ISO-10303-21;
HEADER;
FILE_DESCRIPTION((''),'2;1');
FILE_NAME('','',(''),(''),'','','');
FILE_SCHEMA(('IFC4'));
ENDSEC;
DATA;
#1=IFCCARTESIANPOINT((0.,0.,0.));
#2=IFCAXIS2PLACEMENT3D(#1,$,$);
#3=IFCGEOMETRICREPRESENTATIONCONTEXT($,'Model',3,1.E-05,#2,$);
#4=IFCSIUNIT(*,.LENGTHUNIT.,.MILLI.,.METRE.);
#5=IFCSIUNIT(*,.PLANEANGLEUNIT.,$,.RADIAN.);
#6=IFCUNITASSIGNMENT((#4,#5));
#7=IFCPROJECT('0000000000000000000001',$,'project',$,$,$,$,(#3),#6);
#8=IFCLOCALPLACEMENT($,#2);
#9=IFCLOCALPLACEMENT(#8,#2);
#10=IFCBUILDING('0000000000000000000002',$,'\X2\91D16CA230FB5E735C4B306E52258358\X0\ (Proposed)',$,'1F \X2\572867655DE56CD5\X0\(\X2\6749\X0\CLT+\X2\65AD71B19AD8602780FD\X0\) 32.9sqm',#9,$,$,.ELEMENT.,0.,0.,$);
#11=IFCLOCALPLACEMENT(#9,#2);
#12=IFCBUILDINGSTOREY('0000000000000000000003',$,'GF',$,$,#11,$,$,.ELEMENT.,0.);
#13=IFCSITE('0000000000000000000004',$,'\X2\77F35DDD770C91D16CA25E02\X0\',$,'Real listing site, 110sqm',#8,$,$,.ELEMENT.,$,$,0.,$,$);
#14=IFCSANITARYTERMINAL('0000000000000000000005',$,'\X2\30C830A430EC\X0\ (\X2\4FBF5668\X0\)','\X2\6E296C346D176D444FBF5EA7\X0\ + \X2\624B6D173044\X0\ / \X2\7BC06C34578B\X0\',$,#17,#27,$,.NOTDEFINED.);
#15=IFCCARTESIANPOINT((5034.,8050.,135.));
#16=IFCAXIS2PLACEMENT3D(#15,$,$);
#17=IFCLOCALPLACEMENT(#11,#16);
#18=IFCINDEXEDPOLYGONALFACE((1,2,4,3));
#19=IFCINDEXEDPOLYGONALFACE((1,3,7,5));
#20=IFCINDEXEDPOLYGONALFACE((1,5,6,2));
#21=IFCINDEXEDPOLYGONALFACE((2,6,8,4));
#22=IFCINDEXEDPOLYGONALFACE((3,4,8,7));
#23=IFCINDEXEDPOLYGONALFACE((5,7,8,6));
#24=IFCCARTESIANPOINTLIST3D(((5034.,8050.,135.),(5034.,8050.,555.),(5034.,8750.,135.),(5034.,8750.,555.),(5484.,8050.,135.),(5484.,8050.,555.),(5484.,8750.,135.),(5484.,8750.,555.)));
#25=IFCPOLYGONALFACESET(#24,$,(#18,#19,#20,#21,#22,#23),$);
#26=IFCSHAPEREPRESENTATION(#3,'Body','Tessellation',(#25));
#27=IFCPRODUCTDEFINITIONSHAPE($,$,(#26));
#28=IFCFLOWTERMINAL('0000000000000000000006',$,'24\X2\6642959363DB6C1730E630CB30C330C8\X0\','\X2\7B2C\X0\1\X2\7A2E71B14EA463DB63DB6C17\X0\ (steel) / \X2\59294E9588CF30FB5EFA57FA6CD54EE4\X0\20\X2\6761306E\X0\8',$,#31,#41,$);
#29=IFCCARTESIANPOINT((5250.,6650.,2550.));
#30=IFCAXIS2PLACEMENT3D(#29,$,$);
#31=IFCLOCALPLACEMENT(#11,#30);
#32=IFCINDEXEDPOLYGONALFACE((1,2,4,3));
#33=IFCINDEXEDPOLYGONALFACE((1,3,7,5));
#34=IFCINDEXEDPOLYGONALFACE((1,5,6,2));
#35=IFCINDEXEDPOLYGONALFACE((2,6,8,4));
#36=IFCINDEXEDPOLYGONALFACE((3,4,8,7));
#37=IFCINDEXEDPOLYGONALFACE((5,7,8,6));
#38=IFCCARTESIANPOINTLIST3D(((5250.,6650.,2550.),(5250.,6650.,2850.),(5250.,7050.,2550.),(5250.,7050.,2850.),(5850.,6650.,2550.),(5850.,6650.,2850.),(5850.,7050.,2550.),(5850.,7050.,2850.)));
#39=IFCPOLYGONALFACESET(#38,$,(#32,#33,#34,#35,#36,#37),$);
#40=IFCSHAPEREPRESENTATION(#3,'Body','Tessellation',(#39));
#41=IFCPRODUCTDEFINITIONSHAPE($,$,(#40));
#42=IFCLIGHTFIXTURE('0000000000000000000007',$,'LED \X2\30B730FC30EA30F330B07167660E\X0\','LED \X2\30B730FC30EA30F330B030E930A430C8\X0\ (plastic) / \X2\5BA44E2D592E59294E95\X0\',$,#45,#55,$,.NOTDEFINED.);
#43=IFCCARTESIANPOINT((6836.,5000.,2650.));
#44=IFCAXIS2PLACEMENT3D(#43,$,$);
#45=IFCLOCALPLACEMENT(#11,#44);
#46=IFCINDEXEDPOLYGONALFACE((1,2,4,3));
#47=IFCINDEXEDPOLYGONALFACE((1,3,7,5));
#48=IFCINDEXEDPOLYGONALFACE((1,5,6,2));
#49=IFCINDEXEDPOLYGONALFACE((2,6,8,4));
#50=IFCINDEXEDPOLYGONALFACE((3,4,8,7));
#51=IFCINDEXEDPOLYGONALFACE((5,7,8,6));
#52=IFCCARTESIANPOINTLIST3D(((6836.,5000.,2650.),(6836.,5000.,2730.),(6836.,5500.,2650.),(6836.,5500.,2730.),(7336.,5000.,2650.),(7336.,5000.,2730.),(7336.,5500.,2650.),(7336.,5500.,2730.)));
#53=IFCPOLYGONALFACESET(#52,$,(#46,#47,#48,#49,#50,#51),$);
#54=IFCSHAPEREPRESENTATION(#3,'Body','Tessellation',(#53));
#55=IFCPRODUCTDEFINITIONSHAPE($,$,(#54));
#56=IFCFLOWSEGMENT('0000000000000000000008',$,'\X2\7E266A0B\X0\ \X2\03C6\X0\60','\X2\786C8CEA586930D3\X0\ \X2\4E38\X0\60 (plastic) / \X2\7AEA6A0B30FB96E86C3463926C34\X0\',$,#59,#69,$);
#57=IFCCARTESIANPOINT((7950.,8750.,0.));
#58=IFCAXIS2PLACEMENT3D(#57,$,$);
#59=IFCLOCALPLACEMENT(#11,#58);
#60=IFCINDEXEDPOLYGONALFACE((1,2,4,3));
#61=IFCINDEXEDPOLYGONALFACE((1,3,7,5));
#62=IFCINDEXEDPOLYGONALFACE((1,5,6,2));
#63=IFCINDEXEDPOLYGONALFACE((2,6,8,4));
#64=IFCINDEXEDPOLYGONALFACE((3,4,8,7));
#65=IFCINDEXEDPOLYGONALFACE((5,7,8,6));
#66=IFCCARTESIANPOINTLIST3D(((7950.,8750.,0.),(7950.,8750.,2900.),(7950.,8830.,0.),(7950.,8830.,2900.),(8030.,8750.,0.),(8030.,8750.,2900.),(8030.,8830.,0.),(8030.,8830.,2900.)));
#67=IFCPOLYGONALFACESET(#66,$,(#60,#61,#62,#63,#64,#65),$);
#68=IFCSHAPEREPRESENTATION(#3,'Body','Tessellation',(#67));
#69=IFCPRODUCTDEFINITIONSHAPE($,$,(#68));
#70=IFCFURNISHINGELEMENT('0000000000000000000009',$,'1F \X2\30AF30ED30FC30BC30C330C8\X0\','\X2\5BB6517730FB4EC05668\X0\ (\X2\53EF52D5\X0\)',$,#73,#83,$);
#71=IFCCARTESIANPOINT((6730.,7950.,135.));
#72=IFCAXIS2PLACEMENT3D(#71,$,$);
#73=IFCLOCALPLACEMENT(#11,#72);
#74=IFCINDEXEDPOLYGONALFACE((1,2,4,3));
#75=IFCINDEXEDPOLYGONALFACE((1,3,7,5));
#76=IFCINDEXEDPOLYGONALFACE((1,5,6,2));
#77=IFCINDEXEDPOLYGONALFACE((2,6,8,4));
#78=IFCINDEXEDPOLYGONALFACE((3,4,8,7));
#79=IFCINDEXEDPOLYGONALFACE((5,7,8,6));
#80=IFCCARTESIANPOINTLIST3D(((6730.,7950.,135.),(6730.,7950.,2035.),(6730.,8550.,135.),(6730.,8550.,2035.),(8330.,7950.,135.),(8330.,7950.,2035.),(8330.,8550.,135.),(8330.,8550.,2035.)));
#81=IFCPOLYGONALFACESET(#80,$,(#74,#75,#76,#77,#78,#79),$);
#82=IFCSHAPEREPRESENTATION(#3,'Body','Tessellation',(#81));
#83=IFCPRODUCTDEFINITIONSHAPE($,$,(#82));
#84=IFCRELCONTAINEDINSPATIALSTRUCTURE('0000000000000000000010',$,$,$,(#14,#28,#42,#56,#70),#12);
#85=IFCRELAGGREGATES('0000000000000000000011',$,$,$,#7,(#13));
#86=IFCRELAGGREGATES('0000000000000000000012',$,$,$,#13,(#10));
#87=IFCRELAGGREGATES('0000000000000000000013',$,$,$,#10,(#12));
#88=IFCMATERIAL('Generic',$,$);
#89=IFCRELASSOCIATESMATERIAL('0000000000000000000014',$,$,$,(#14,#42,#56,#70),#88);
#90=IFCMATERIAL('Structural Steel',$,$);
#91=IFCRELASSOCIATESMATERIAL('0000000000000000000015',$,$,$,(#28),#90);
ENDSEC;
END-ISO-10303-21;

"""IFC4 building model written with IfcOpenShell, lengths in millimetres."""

from ifc_helpers import new_model, si_unit, frame, frame_2d, origin, place, context, project, spatial, rectangle, extrude, material, element, save


model = new_model("IFC4")

# Units and contexts
model_context = context("Model", 3, precision=1e-05, world=origin())
ifc_project = project(units=[si_unit("LENGTHUNIT", "METRE", prefix="MILLI"), si_unit("PLANEANGLEUNIT", "RADIAN")], contexts=[model_context])

# Site, building, storey
site_placement = place(None, origin())
site = spatial("IfcSite", under=ifc_project, at=site_placement, Name="石川県金沢市", ObjectType="Real listing site, 110sqm", CompositionType="ELEMENT", RefElevation=0.0)
building_placement = place(site_placement, origin())
building = spatial("IfcBuilding", under=site, at=building_placement, Name="金沢・平屋の別荘 (Proposed)", ObjectType="1F 在来工法(杉CLT+断熱高性能) 32.9sqm", CompositionType="ELEMENT", ElevationOfRefHeight=0.0, ElevationOfTerrain=0.0)
storey_placement = place(building_placement, origin())
storey = spatial("IfcBuildingStorey", under=building, at=storey_placement, Name="GF", CompositionType="ELEMENT", Elevation=0.0)

# Shared definitions
ifc_material_1 = material(Name="Generic")

# Sanitary terminal
sanitary_terminal_1_placement = place(storey_placement, frame((5034.0, 8050.0, 135.0)))
element("IfcSanitaryTerminal", 1, at=sanitary_terminal_1_placement, inside=storey, material=ifc_material_1, Name="トイレ (便器)", Description="温水洗浄便座 + 手洗い / 節水型", PredefinedType="NOTDEFINED", context=model_context, shape_type="SweptSolid", body=[
    extrude(rectangle(XDim=450.0, YDim=700.0, at=frame_2d((225.0, 350.0))), frame((5034.0, 8050.0, 135.0)), (0.0, 0.0, 1.0), 420.0),
])

# Flow terminal
ifc_material_2 = material(Name="Structural Steel")
flow_terminal_placement = place(storey_placement, frame((5250.0, 6650.0, 2550.0)))
element("IfcFlowTerminal", 2, at=flow_terminal_placement, inside=storey, material=ifc_material_2, Name="24時間換気ユニット", Description="第1種熱交換換気 (steel) / 天井裏・建基法令20条の8", context=model_context, shape_type="SweptSolid", body=[
    extrude(rectangle(XDim=600.0, YDim=400.0, at=frame_2d((300.0, 200.0))), frame((5250.0, 6650.0, 2550.0)), (0.0, 0.0, 1.0), 300.0),
])

# Light fixture
light_fixture_placement = place(storey_placement, frame((6836.0, 5000.0, 2650.0)))
element("IfcLightFixture", 3, at=light_fixture_placement, inside=storey, material=ifc_material_1, Name="LED シーリング照明", Description="LED シーリングライト (plastic) / 室中央天井", PredefinedType="NOTDEFINED", context=model_context, shape_type="SweptSolid", body=[
    extrude(rectangle(XDim=500.0, YDim=500.0, at=frame_2d((250.0, 250.0))), frame((6836.0, 5000.0, 2650.0)), (0.0, 0.0, 1.0), 80.0),
])

# Flow segment
flow_segment_placement = place(storey_placement, frame((7950.0, 8750.0, 0.0)))
element("IfcFlowSegment", 4, at=flow_segment_placement, inside=storey, material=ifc_material_1, Name="縦樋 φ60", Description="硬質塩ビ 丸60 (plastic) / 竪樋・雨水排水", context=model_context, shape_type="SweptSolid", body=[
    extrude(rectangle(XDim=80.0, YDim=80.0, at=frame_2d((40.0, 40.0))), frame((7950.0, 8750.0, 0.0)), (0.0, 0.0, 1.0), 2900.0),
])

# Furnishing element
furnishing_placement = place(storey_placement, frame((6730.0, 7950.0, 135.0)))
element("IfcFurnishingElement", 5, at=furnishing_placement, inside=storey, material=ifc_material_1, Name="1F クローゼット", Description="家具・什器 (可動)", context=model_context, shape_type="SweptSolid", body=[
    extrude(rectangle(XDim=1600.0, YDim=600.0, at=frame_2d((800.0, 300.0))), frame((6730.0, 7950.0, 135.0)), (0.0, 0.0, 1.0), 1900.0),
])

save(model, "model.ifc")
